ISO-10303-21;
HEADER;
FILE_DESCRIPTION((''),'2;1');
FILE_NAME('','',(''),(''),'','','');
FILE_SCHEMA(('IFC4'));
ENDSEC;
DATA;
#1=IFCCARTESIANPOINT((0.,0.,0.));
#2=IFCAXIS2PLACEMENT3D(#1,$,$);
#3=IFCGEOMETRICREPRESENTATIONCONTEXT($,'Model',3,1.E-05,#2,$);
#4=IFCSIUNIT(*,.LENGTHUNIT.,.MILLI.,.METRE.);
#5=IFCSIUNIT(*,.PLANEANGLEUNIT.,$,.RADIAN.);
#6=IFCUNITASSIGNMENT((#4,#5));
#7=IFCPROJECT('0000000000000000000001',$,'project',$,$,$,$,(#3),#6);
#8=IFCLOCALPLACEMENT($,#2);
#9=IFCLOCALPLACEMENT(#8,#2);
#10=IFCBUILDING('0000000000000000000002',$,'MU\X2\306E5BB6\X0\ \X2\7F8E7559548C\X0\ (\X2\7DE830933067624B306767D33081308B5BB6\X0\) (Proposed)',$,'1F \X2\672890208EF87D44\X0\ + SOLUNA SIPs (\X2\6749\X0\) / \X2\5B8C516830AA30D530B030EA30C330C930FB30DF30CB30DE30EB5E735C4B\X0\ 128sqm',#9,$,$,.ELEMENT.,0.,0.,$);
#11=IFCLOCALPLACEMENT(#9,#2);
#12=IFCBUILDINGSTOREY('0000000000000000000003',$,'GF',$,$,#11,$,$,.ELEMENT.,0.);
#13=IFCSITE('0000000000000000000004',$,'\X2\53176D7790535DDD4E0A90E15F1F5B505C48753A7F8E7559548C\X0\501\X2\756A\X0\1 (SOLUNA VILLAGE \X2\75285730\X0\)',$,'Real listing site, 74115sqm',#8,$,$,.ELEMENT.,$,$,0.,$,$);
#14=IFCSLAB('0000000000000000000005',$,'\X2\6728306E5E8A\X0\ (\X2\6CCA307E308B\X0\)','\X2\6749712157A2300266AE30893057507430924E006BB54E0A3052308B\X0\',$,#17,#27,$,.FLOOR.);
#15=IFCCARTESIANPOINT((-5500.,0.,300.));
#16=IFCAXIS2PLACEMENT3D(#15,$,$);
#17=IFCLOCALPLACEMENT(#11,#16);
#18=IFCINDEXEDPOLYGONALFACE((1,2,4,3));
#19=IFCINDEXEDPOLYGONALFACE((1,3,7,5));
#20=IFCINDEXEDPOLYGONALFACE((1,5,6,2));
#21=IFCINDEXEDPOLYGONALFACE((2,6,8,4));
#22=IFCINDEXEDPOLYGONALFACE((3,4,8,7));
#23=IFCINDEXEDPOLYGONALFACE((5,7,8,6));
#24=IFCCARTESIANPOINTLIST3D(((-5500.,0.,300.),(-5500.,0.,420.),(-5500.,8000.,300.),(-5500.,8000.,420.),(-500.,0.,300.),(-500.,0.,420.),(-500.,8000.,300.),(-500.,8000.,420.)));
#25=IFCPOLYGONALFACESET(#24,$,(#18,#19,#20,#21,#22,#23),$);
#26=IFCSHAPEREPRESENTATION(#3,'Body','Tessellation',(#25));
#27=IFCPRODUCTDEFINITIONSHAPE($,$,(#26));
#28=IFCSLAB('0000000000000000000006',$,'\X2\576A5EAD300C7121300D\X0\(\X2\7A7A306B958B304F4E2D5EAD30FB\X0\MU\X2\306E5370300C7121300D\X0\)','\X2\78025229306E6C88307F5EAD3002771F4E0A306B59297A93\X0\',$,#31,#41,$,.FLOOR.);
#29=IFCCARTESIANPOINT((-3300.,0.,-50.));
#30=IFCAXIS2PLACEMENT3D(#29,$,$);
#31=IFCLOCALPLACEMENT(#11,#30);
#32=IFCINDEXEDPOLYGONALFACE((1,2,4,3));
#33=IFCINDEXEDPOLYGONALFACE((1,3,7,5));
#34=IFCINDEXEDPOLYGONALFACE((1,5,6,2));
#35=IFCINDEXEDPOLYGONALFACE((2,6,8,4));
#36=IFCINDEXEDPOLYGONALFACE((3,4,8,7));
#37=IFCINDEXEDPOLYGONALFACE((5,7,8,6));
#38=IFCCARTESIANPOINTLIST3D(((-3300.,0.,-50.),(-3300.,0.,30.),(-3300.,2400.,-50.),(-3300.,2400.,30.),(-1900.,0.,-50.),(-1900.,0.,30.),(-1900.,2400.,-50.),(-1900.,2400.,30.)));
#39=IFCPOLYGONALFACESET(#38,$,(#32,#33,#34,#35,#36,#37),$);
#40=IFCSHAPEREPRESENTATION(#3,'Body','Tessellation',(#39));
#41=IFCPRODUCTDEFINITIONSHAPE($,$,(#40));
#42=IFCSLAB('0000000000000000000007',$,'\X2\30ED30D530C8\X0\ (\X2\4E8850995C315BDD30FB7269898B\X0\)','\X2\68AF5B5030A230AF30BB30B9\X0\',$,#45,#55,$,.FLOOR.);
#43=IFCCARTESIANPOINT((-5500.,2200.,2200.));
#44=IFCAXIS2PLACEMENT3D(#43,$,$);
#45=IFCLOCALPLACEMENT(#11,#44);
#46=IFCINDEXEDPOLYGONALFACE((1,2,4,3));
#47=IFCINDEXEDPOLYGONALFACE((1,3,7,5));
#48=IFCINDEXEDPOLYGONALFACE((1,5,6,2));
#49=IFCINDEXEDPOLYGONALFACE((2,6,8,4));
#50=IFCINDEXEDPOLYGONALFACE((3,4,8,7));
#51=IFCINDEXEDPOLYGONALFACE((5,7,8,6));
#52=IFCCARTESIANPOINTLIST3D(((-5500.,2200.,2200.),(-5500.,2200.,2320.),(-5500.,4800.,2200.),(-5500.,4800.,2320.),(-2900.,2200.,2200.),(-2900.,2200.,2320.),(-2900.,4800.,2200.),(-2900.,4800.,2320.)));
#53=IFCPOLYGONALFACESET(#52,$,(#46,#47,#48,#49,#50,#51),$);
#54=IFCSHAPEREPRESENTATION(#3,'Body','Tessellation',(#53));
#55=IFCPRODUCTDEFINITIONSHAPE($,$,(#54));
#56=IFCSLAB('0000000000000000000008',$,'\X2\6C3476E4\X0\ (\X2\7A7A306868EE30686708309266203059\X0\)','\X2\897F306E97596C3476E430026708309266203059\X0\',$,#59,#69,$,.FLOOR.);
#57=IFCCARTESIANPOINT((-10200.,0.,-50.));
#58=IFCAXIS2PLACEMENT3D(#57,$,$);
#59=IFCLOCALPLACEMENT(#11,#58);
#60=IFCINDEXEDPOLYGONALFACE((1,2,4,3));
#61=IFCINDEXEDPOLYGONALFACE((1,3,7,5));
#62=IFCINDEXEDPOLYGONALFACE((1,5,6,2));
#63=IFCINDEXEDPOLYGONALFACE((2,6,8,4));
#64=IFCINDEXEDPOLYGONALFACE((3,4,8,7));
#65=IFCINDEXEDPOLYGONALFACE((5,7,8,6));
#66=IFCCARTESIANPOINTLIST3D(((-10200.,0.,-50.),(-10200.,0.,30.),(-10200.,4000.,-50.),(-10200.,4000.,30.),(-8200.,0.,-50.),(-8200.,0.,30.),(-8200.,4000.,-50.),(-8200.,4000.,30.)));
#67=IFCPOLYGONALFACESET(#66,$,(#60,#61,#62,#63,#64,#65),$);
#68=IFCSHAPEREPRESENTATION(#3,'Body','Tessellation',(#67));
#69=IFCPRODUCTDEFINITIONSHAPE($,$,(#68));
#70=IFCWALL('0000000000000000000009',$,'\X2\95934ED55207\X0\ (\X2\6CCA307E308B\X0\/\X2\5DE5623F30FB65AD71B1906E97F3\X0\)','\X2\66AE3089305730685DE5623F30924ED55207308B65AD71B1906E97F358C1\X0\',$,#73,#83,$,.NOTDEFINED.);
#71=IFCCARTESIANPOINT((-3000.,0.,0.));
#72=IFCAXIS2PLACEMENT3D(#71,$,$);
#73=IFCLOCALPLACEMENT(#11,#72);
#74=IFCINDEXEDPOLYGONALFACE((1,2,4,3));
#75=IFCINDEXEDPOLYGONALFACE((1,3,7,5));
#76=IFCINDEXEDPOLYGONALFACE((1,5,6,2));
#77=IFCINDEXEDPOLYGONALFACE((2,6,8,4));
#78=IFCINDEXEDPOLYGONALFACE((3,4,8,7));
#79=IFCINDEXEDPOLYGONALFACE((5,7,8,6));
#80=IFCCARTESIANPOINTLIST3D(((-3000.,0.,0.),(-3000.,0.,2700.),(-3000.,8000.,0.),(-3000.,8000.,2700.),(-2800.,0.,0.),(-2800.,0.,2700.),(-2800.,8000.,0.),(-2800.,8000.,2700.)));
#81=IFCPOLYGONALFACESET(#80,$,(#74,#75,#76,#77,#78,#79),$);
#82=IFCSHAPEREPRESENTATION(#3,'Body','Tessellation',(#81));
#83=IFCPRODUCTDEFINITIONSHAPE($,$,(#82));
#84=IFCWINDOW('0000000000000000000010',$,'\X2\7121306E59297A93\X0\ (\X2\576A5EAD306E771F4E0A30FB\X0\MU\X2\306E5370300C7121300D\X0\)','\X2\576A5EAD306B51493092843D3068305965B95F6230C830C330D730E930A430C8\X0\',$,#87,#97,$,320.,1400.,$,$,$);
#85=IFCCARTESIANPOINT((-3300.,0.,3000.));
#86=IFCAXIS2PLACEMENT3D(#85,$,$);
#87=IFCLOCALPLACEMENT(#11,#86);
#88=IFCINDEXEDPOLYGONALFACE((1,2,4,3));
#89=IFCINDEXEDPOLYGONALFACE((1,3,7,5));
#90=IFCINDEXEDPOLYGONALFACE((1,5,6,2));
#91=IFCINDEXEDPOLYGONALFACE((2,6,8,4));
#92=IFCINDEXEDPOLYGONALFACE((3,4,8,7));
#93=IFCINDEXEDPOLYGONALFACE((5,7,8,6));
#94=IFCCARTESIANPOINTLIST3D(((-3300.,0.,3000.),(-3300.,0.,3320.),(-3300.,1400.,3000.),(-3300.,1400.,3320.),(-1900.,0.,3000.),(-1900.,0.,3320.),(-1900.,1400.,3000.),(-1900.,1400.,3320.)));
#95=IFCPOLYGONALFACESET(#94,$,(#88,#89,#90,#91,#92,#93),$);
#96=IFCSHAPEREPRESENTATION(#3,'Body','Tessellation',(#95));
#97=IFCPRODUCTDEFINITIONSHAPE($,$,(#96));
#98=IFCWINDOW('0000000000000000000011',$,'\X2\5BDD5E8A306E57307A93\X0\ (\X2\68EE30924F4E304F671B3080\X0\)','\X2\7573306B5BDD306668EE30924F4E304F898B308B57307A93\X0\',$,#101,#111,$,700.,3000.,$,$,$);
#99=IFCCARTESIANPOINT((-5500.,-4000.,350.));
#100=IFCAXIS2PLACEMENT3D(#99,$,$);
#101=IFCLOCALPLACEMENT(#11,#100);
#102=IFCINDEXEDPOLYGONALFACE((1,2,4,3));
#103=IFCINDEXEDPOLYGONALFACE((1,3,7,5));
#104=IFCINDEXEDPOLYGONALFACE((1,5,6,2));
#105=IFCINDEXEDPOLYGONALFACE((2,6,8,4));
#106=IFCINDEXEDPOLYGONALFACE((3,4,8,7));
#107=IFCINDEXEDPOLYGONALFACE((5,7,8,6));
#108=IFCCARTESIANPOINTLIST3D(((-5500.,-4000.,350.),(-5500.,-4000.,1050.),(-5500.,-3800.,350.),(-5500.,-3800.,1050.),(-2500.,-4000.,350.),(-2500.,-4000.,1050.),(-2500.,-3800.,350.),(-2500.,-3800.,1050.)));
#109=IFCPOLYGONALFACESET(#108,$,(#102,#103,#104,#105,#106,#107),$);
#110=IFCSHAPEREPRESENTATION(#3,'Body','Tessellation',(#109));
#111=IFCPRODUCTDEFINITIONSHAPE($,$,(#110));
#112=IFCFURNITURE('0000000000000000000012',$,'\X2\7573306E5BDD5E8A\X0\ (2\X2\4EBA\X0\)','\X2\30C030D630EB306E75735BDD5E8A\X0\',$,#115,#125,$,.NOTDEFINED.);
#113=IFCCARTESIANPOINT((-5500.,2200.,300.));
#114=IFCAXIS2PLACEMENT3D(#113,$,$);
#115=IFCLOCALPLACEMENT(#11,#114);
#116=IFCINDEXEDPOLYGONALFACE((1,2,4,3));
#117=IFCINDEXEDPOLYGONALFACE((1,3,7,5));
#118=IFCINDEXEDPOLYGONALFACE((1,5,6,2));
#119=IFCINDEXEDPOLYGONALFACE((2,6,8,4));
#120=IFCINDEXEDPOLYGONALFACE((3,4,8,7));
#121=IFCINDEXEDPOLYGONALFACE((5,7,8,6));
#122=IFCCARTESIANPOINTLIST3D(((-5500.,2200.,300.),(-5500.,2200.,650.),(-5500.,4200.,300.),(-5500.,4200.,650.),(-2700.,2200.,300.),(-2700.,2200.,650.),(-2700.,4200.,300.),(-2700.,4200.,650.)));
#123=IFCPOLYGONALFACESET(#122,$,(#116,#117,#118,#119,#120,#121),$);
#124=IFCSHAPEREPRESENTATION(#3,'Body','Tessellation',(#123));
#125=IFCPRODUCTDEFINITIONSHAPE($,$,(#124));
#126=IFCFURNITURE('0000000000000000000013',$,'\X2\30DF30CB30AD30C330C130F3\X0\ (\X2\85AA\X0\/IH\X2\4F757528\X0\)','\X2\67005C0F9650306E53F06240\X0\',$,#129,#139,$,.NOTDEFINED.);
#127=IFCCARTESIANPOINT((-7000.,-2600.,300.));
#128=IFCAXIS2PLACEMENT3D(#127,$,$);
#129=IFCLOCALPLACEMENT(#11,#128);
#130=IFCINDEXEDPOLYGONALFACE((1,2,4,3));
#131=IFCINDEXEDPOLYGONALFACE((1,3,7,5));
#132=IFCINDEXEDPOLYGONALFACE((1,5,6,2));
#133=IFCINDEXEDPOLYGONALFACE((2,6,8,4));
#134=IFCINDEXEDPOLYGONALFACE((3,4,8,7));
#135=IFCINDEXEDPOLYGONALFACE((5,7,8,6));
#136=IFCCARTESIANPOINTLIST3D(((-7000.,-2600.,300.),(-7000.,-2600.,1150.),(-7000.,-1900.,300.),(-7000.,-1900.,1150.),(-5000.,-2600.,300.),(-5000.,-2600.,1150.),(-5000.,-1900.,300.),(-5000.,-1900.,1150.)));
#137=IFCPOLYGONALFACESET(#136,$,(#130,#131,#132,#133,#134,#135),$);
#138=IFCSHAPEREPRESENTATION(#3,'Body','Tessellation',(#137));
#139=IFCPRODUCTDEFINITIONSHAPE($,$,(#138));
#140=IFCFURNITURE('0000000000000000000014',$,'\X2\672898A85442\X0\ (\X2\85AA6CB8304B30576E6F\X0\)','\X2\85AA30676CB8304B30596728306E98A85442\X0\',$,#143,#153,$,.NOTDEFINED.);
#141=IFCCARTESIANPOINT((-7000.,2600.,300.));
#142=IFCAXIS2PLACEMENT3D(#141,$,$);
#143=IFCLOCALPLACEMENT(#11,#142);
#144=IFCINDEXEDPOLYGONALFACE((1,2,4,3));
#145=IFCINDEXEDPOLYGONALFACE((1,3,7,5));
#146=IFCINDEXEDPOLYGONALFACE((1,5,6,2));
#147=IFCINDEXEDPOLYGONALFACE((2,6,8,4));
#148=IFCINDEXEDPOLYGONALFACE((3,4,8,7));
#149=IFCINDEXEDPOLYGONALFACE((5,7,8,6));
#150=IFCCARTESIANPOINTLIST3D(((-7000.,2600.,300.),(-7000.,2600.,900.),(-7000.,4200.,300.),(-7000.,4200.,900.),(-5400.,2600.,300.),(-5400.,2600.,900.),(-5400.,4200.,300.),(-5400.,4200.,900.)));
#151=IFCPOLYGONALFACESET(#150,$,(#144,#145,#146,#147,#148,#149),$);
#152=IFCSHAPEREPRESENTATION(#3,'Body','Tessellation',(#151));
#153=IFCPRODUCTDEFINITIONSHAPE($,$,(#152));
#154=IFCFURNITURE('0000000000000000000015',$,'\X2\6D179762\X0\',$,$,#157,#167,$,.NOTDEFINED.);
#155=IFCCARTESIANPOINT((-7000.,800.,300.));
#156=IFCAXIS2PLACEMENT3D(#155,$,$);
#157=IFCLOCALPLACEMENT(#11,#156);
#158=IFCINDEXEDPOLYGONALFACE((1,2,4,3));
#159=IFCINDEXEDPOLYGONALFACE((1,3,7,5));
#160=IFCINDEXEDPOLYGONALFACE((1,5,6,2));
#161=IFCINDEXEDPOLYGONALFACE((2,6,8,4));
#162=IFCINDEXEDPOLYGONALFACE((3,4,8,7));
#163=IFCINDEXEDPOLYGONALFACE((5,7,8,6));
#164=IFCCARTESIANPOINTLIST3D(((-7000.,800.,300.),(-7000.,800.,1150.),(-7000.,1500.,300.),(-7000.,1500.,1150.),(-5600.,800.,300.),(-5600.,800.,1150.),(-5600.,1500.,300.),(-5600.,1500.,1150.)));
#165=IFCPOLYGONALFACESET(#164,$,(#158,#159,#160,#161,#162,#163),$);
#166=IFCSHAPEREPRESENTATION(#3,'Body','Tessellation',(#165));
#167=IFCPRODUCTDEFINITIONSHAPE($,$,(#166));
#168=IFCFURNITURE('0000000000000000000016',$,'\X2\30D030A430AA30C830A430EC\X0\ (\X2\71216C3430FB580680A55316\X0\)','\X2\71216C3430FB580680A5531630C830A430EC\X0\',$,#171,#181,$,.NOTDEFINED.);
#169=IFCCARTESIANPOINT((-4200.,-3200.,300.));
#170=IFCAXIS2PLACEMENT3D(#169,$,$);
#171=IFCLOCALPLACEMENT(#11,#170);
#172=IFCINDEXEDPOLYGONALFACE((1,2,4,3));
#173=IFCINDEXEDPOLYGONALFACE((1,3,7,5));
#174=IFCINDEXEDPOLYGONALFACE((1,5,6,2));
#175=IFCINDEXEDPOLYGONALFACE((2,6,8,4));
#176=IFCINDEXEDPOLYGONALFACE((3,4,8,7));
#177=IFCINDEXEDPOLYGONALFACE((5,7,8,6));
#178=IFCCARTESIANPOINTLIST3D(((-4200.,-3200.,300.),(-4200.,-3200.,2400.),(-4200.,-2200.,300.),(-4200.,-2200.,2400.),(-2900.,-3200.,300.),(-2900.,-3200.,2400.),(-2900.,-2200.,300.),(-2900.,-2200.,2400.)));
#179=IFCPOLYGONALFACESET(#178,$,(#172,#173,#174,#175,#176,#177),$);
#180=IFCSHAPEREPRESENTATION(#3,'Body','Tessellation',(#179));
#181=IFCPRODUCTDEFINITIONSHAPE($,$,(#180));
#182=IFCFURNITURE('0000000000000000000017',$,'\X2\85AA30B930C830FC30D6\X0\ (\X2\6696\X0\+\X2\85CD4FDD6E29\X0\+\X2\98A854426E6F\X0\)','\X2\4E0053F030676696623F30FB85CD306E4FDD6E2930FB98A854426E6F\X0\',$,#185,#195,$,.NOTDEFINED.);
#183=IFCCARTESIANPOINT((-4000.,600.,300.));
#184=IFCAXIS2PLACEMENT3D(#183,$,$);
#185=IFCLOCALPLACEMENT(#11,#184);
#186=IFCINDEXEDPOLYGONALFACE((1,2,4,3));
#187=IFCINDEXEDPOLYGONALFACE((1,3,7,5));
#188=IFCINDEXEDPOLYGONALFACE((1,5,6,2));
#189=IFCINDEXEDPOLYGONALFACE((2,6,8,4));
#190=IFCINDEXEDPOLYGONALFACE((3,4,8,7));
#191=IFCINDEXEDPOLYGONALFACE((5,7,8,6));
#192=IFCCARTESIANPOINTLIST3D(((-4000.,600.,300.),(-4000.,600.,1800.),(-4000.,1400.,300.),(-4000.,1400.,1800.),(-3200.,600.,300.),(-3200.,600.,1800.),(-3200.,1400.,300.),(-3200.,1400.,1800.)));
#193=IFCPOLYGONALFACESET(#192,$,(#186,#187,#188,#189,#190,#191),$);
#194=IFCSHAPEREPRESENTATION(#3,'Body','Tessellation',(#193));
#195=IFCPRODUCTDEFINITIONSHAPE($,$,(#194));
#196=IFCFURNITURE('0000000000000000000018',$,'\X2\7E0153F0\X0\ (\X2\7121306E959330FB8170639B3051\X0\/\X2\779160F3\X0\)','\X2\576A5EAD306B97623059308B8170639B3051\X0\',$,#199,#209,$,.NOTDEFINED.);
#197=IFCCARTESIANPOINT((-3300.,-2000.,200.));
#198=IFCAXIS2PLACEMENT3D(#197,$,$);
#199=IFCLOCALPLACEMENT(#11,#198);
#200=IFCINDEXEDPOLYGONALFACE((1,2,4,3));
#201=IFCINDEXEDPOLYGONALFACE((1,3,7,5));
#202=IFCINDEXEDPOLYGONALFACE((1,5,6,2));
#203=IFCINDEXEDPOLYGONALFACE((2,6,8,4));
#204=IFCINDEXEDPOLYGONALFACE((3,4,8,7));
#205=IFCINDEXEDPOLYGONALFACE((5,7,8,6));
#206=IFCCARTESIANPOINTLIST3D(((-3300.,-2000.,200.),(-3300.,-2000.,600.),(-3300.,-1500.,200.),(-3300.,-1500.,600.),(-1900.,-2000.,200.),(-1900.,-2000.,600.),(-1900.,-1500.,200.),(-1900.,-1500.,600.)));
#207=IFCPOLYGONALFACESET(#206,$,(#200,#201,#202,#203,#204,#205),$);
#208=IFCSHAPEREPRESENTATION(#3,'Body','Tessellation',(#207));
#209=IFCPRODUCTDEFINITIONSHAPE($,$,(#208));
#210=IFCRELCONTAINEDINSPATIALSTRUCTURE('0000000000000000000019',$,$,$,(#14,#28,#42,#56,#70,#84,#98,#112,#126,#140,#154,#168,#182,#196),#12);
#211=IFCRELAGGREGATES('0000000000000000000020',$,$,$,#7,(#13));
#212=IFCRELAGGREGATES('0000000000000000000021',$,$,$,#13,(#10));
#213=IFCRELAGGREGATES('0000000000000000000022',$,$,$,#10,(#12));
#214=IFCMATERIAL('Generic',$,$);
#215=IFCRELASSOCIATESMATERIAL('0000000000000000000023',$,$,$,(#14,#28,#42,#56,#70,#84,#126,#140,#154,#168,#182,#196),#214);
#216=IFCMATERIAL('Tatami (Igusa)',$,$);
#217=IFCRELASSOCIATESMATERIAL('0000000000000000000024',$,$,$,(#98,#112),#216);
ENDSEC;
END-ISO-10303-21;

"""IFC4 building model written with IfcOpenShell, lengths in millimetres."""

from ifc_helpers import new_model, si_unit, frame, frame_2d, origin, place, context, project, spatial, rectangle, extrude, material, element, save


model = new_model("IFC4")

# Units and contexts
model_context = context("Model", 3, precision=1e-05, world=origin())
ifc_project = project(units=[si_unit("LENGTHUNIT", "METRE", prefix="MILLI"), si_unit("PLANEANGLEUNIT", "RADIAN")], contexts=[model_context])

# Site, building, storey
site_placement = place(None, origin())
site = spatial("IfcSite", under=ifc_project, at=site_placement, Name="北海道川上郡弟子屈町美留和501番1 (SOLUNA VILLAGE 用地)", ObjectType="Real listing site, 74115sqm", CompositionType="ELEMENT", RefElevation=0.0)
building_placement = place(site_placement, origin())
building = spatial("IfcBuilding", under=site, at=building_placement, Name="MUの家 美留和 (編んで手で染める家) (Proposed)", ObjectType="1F 木造軸組 + SOLUNA SIPs (杉) / 完全オフグリッド・ミニマル平屋 128sqm", CompositionType="ELEMENT", ElevationOfRefHeight=0.0, ElevationOfTerrain=0.0)
storey_placement = place(building_placement, origin())
storey = spatial("IfcBuildingStorey", under=building, at=storey_placement, Name="GF", CompositionType="ELEMENT", Elevation=0.0)

# Slabs
ifc_material_1 = material(Name="Generic")
slab_1_placement = place(storey_placement, frame((-5500.0, 0.0, 300.0)))
element("IfcSlab", 1, at=slab_1_placement, inside=storey, material=ifc_material_1, Name="木の床 (泊まる)", Description="杉無垢。暮らし側を一段上げる", PredefinedType="FLOOR", context=model_context, shape_type="SweptSolid", body=[
    extrude(rectangle(XDim=5000.0, YDim=8000.0, at=frame_2d((2500.0, 4000.0))), frame((-5500.0, 0.0, 300.0)), (0.0, 0.0, 1.0), 120.0),
])
slab_2_placement = place(storey_placement, frame((-3300.0, 0.0, -50.0)))
element("IfcSlab", 2, at=slab_2_placement, inside=storey, material=ifc_material_1, Name="坪庭「無」(空に開く中庭・MUの印「無」)", Description="砂利の沈み庭。真上に天窓", PredefinedType="FLOOR", context=model_context, shape_type="SweptSolid", body=[
    extrude(rectangle(XDim=1400.0, YDim=2400.0, at=frame_2d((700.0, 1200.0))), frame((-3300.0, 0.0, -50.0)), (0.0, 0.0, 1.0), 80.0),
])
slab_3_placement = place(storey_placement, frame((-5500.0, 2200.0, 2200.0)))
element("IfcSlab", 3, at=slab_3_placement, inside=storey, material=ifc_material_1, Name="ロフト (予備就寝・物見)", Description="梯子アクセス", PredefinedType="FLOOR", context=model_context, shape_type="SweptSolid", body=[
    extrude(rectangle(XDim=2600.0, YDim=2600.0, at=frame_2d((1300.0, 1300.0))), frame((-5500.0, 2200.0, 2200.0)), (0.0, 0.0, 1.0), 120.0),
])
slab_4_placement = place(storey_placement, frame((-10200.0, 0.0, -50.0)))
element("IfcSlab", 4, at=slab_4_placement, inside=storey, material=ifc_material_1, Name="水盤 (空と森と月を映す)", Description="西の静水盤。月を映す", PredefinedType="FLOOR", context=model_context, shape_type="SweptSolid", body=[
    extrude(rectangle(XDim=2000.0, YDim=4000.0, at=frame_2d((1000.0, 2000.0))), frame((-10200.0, 0.0, -50.0)), (0.0, 0.0, 1.0), 80.0),
])

# Wall
wall_1_placement = place(storey_placement, frame((-3000.0, 0.0, 0.0)))
element("IfcWall", 5, at=wall_1_placement, inside=storey, material=ifc_material_1, Name="間仕切 (泊まる/工房・断熱遮音)", Description="暮らしと工房を仕切る断熱遮音壁", PredefinedType="NOTDEFINED", context=model_context, shape_type="SweptSolid", body=[
    extrude(rectangle(XDim=200.0, YDim=8000.0, at=frame_2d((100.0, 4000.0))), frame((-3000.0, 0.0, 0.0)), (0.0, 0.0, 1.0), 2700.0),
])

# Windows
window_1_placement = place(storey_placement, frame((-3300.0, 0.0, 3000.0)))
element("IfcWindow", 6, at=window_1_placement, inside=storey, material=ifc_material_1, Name="無の天窓 (坪庭の真上・MUの印「無」)", Description="坪庭に光を落とす方形トップライト", OverallHeight=320.0, OverallWidth=1400.0, context=model_context, shape_type="SweptSolid", body=[
    extrude(rectangle(XDim=1400.0, YDim=1400.0, at=frame_2d((700.0, 700.0))), frame((-3300.0, 0.0, 3000.0)), (0.0, 0.0, 1.0), 320.0),
])
ifc_material_2 = material(Name="Tatami (Igusa)")
window_2_placement = place(storey_placement, frame((-5500.0, -4000.0, 350.0)))
element("IfcWindow", 7, at=window_2_placement, inside=storey, material=ifc_material_2, Name="寝床の地窓 (森を低く望む)", Description="畳に寝て森を低く見る地窓", OverallHeight=700.0, OverallWidth=3000.0, context=model_context, shape_type="SweptSolid", body=[
    extrude(rectangle(XDim=3000.0, YDim=200.0, at=frame_2d((1500.0, 100.0))), frame((-5500.0, -4000.0, 350.0)), (0.0, 0.0, 1.0), 700.0),
])

# Furniture
furniture_1_placement = place(storey_placement, frame((-5500.0, 2200.0, 300.0)))
element("IfcFurniture", 8, at=furniture_1_placement, inside=storey, material=ifc_material_2, Name="畳の寝床 (2人)", Description="ダブルの畳寝床", PredefinedType="NOTDEFINED", context=model_context, shape_type="SweptSolid", body=[
    extrude(rectangle(XDim=2800.0, YDim=2000.0, at=frame_2d((1400.0, 1000.0))), frame((-5500.0, 2200.0, 300.0)), (0.0, 0.0, 1.0), 350.0),
])
furniture_2_placement = place(storey_placement, frame((-7000.0, -2600.0, 300.0)))
element("IfcFurniture", 9, at=furniture_2_placement, inside=storey, material=ifc_material_1, Name="ミニキッチン (薪/IH併用)", Description="最小限の台所", PredefinedType="NOTDEFINED", context=model_context, shape_type="SweptSolid", body=[
    extrude(rectangle(XDim=2000.0, YDim=700.0, at=frame_2d((1000.0, 350.0))), frame((-7000.0, -2600.0, 300.0)), (0.0, 0.0, 1.0), 850.0),
])
furniture_3_placement = place(storey_placement, frame((-7000.0, 2600.0, 300.0)))
element("IfcFurniture", 10, at=furniture_3_placement, inside=storey, material=ifc_material_1, Name="木風呂 (薪沸かし湯)", Description="薪で沸かす木の風呂", PredefinedType="NOTDEFINED", context=model_context, shape_type="SweptSolid", body=[
    extrude(rectangle(XDim=1600.0, YDim=1600.0, at=frame_2d((800.0, 800.0))), frame((-7000.0, 2600.0, 300.0)), (0.0, 0.0, 1.0), 600.0),
])
furniture_4_placement = place(storey_placement, frame((-7000.0, 800.0, 300.0)))
element("IfcFurniture", 11, at=furniture_4_placement, inside=storey, material=ifc_material_1, Name="洗面", PredefinedType="NOTDEFINED", context=model_context, shape_type="SweptSolid", body=[
    extrude(rectangle(XDim=1400.0, YDim=700.0, at=frame_2d((700.0, 350.0))), frame((-7000.0, 800.0, 300.0)), (0.0, 0.0, 1.0), 850.0),
])
furniture_5_placement = place(storey_placement, frame((-4200.0, -3200.0, 300.0)))
element("IfcFurniture", 12, at=furniture_5_placement, inside=storey, material=ifc_material_1, Name="バイオトイレ (無水・堆肥化)", Description="無水・堆肥化トイレ", PredefinedType="NOTDEFINED", context=model_context, shape_type="SweptSolid", body=[
    extrude(rectangle(XDim=1300.0, YDim=1000.0, at=frame_2d((650.0, 500.0))), frame((-4200.0, -3200.0, 300.0)), (0.0, 0.0, 1.0), 2100.0),
])
furniture_6_placement = place(storey_placement, frame((-4000.0, 600.0, 300.0)))
element("IfcFurniture", 13, at=furniture_6_placement, inside=storey, material=ifc_material_1, Name="薪ストーブ (暖+藍保温+風呂湯)", Description="一台で暖房・藍の保温・風呂湯", PredefinedType="NOTDEFINED", context=model_context, shape_type="SweptSolid", body=[
    extrude(rectangle(XDim=800.0, YDim=800.0, at=frame_2d((400.0, 400.0))), frame((-4000.0, 600.0, 300.0)), (0.0, 0.0, 1.0), 1500.0),
])
furniture_7_placement = place(storey_placement, frame((-3300.0, -2000.0, 200.0)))
element("IfcFurniture", 14, at=furniture_7_placement, inside=storey, material=ifc_material_1, Name="縁台 (無の間・腰掛け/瞑想)", Description="坪庭に面する腰掛け", PredefinedType="NOTDEFINED", context=model_context, shape_type="SweptSolid", body=[
    extrude(rectangle(XDim=1400.0, YDim=500.0, at=frame_2d((700.0, 250.0))), frame((-3300.0, -2000.0, 200.0)), (0.0, 0.0, 1.0), 400.0),
])

save(model, "model.ifc")
